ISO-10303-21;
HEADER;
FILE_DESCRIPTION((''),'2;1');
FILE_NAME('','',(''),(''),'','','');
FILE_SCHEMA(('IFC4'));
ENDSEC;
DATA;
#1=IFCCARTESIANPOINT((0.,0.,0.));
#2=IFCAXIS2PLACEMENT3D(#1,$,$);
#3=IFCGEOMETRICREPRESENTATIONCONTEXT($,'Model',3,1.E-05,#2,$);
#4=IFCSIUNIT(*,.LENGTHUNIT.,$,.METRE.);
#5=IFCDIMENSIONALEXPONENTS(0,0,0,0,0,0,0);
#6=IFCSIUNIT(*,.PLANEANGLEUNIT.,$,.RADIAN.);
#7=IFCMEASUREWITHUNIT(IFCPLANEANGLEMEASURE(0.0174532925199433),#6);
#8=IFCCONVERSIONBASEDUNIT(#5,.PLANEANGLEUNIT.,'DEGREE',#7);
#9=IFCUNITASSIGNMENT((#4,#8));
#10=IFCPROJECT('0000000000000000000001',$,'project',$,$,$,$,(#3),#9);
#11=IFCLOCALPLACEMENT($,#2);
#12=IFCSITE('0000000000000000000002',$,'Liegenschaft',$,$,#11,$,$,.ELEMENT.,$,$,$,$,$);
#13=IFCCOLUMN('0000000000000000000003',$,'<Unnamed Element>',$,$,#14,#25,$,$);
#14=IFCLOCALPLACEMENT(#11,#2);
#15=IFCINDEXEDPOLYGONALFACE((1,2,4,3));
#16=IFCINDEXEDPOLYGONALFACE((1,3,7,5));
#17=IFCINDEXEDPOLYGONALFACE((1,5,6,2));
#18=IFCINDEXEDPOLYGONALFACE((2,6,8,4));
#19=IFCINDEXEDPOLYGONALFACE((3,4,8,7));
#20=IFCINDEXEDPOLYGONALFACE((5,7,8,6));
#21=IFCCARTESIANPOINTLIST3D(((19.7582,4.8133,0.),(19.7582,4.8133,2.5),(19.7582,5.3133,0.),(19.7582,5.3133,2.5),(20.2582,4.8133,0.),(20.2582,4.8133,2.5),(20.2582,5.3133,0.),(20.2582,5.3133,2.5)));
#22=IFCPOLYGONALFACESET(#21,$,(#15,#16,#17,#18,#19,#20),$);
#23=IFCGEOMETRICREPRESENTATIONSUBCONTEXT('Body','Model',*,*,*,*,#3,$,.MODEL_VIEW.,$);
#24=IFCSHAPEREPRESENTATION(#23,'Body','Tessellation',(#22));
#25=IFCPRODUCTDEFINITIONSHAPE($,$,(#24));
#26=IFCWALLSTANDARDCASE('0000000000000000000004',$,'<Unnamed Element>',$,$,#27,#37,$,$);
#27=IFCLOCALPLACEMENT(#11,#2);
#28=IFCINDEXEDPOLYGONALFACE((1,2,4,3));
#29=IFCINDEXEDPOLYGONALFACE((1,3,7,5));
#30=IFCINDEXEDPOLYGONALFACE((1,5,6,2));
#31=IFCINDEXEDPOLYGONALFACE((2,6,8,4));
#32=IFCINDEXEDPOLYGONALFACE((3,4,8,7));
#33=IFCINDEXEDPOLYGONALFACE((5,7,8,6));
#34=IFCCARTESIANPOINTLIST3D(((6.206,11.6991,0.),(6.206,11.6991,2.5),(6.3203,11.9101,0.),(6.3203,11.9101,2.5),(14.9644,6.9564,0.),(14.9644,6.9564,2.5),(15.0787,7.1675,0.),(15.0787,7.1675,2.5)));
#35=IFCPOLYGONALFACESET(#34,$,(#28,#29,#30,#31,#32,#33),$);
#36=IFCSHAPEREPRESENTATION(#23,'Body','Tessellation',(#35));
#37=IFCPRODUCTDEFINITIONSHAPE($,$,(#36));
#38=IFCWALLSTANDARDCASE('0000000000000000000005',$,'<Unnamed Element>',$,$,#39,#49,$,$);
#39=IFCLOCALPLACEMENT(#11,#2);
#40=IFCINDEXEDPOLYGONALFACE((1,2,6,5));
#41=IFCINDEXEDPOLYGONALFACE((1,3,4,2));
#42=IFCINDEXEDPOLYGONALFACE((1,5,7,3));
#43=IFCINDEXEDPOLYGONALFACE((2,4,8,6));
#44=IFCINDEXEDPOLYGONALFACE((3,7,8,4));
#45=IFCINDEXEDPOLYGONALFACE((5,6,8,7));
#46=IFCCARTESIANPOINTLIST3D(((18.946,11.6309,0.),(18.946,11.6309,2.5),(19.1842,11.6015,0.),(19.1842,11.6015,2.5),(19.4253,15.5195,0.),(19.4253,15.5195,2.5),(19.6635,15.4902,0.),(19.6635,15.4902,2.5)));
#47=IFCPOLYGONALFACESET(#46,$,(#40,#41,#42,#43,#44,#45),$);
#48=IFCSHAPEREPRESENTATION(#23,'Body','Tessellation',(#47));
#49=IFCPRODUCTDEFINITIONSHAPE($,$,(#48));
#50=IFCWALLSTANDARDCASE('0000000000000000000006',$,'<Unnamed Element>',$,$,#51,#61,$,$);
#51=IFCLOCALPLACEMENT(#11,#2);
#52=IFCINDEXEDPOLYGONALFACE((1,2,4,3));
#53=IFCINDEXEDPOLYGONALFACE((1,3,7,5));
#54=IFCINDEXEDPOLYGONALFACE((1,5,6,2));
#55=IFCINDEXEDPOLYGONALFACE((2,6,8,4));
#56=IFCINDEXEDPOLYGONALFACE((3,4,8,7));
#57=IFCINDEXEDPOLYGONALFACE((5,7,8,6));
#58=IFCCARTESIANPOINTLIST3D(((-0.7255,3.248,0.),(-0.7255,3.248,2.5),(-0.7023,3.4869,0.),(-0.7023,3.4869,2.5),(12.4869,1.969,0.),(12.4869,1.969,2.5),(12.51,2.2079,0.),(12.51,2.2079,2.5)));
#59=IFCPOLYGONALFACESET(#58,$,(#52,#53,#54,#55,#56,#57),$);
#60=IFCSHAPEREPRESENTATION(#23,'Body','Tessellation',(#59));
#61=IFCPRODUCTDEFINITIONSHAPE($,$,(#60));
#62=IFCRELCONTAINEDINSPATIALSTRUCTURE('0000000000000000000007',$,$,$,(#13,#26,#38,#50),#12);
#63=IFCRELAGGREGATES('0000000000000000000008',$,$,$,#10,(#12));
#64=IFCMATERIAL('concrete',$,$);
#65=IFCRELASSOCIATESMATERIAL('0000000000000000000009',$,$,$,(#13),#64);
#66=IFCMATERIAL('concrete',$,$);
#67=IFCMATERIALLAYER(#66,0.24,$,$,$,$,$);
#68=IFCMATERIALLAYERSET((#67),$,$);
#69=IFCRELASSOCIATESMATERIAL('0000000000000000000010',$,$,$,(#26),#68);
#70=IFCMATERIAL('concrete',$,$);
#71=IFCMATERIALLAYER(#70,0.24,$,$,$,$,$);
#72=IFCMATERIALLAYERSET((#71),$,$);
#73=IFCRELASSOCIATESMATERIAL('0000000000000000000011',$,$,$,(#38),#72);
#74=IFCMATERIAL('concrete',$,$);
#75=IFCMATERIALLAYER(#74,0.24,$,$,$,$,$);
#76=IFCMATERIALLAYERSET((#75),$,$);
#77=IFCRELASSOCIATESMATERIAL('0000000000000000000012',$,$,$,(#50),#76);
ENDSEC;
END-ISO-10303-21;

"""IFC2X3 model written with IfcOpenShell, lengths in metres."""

from ifc_helpers import new_model, entity, si_unit, converted_unit, frame, frame_2d, origin, origin_with_axes, place, context, subcontext, project, spatial, rectangle, extrude, material, layer, layer_set, layer_usage, element, save


model = new_model("IFC2X3")

# Units and contexts
model_context = context("Model", 3, precision=1e-05, world=origin())
body_context = subcontext(model_context, "Body", "Model", "MODEL_VIEW")
ifc_project = project(units=[si_unit("LENGTHUNIT", "METRE"), converted_unit("PLANEANGLEUNIT", "DEGREE", entity("IfcPlaneAngleMeasure", 0.0174532925199433), si_unit("PLANEANGLEUNIT", "RADIAN"), dimensions=[0, 0, 0, 0, 0, 0, 0])], contexts=[model_context])

# Site
site_placement = place(None, origin())
site = spatial("IfcSite", under=ifc_project, at=site_placement, Name="Liegenschaft", CompositionType="ELEMENT")

# Column
ifc_material_1 = material(Name="concrete")
column_placement = place(site_placement, frame((19.7582, 4.8133, 0.0), z_axis=(0.0, 0.0, 1.0), x_axis=(1.0, 0.0, 0.0)))
element("IfcColumn", 1, at=column_placement, inside=site, material=ifc_material_1, Name="<Unnamed Element>", context=body_context, shape_type="SweptSolid", body=[
    extrude(rectangle(XDim=0.5, YDim=0.5, at=frame_2d((0.25, 0.25), x_axis=(1.0, 0.0))), origin_with_axes(), (0.0, 0.0, 1.0), 2.5),
])

# Walls
ifc_material_2 = material(Name="concrete")
ifc_layer_1 = layer(ifc_material_2, 0.24)
ifc_layer_set_1 = layer_set([ifc_layer_1])
ifc_layer_usage_1 = layer_usage(ifc_layer_set_1, "AXIS2", "POSITIVE", 0.0)
wall_1_placement = place(site_placement, frame((6.206, 11.6991, 0.0), z_axis=(0.0, 0.0, 1.0), x_axis=(0.879353, -0.47617, 0.0)))
element("IfcWallStandardCase", 2, at=wall_1_placement, inside=site, material=ifc_layer_usage_1, Name="<Unnamed Element>", context=body_context, shape_type="SweptSolid", body=[
    extrude(rectangle(XDim=9.96, YDim=0.24, at=frame_2d((4.98, 0.12), x_axis=(1.0, 0.0))), origin_with_axes(), (0.0, 0.0, 1.0), 2.5),
])
ifc_material_3 = material(Name="concrete")
ifc_layer_2 = layer(ifc_material_3, 0.24)
ifc_layer_set_2 = layer_set([ifc_layer_2])
ifc_layer_usage_2 = layer_usage(ifc_layer_set_2, "AXIS2", "POSITIVE", 0.0)
wall_2_placement = place(site_placement, frame((19.1842, 11.6015, 0.0), z_axis=(0.0, 0.0, 1.0), x_axis=(0.12233, 0.992489, 0.0)))
element("IfcWallStandardCase", 3, at=wall_2_placement, inside=site, material=ifc_layer_usage_2, Name="<Unnamed Element>", context=body_context, shape_type="SweptSolid", body=[
    extrude(rectangle(XDim=3.9181, YDim=0.24, at=frame_2d((1.959, 0.12), x_axis=(1.0, 0.0))), origin_with_axes(), (0.0, 0.0, 1.0), 2.5),
])
ifc_material_4 = material(Name="concrete")
ifc_layer_3 = layer(ifc_material_4, 0.24)
ifc_layer_set_3 = layer_set([ifc_layer_3])
ifc_layer_usage_3 = layer_usage(ifc_layer_set_3, "AXIS2", "POSITIVE", 0.0)
wall_3_placement = place(site_placement, frame((-0.7255, 3.248, 0.0), z_axis=(0.0, 0.0, 1.0), x_axis=(0.995347, -0.096352, 0.0)))
element("IfcWallStandardCase", 4, at=wall_3_placement, inside=site, material=ifc_layer_usage_3, Name="<Unnamed Element>", context=body_context, shape_type="SweptSolid", body=[
    extrude(rectangle(XDim=13.2741, YDim=0.24, at=frame_2d((6.6371, 0.12), x_axis=(1.0, 0.0))), origin_with_axes(), (0.0, 0.0, 1.0), 2.5),
])

save(model, "model.ifc")
